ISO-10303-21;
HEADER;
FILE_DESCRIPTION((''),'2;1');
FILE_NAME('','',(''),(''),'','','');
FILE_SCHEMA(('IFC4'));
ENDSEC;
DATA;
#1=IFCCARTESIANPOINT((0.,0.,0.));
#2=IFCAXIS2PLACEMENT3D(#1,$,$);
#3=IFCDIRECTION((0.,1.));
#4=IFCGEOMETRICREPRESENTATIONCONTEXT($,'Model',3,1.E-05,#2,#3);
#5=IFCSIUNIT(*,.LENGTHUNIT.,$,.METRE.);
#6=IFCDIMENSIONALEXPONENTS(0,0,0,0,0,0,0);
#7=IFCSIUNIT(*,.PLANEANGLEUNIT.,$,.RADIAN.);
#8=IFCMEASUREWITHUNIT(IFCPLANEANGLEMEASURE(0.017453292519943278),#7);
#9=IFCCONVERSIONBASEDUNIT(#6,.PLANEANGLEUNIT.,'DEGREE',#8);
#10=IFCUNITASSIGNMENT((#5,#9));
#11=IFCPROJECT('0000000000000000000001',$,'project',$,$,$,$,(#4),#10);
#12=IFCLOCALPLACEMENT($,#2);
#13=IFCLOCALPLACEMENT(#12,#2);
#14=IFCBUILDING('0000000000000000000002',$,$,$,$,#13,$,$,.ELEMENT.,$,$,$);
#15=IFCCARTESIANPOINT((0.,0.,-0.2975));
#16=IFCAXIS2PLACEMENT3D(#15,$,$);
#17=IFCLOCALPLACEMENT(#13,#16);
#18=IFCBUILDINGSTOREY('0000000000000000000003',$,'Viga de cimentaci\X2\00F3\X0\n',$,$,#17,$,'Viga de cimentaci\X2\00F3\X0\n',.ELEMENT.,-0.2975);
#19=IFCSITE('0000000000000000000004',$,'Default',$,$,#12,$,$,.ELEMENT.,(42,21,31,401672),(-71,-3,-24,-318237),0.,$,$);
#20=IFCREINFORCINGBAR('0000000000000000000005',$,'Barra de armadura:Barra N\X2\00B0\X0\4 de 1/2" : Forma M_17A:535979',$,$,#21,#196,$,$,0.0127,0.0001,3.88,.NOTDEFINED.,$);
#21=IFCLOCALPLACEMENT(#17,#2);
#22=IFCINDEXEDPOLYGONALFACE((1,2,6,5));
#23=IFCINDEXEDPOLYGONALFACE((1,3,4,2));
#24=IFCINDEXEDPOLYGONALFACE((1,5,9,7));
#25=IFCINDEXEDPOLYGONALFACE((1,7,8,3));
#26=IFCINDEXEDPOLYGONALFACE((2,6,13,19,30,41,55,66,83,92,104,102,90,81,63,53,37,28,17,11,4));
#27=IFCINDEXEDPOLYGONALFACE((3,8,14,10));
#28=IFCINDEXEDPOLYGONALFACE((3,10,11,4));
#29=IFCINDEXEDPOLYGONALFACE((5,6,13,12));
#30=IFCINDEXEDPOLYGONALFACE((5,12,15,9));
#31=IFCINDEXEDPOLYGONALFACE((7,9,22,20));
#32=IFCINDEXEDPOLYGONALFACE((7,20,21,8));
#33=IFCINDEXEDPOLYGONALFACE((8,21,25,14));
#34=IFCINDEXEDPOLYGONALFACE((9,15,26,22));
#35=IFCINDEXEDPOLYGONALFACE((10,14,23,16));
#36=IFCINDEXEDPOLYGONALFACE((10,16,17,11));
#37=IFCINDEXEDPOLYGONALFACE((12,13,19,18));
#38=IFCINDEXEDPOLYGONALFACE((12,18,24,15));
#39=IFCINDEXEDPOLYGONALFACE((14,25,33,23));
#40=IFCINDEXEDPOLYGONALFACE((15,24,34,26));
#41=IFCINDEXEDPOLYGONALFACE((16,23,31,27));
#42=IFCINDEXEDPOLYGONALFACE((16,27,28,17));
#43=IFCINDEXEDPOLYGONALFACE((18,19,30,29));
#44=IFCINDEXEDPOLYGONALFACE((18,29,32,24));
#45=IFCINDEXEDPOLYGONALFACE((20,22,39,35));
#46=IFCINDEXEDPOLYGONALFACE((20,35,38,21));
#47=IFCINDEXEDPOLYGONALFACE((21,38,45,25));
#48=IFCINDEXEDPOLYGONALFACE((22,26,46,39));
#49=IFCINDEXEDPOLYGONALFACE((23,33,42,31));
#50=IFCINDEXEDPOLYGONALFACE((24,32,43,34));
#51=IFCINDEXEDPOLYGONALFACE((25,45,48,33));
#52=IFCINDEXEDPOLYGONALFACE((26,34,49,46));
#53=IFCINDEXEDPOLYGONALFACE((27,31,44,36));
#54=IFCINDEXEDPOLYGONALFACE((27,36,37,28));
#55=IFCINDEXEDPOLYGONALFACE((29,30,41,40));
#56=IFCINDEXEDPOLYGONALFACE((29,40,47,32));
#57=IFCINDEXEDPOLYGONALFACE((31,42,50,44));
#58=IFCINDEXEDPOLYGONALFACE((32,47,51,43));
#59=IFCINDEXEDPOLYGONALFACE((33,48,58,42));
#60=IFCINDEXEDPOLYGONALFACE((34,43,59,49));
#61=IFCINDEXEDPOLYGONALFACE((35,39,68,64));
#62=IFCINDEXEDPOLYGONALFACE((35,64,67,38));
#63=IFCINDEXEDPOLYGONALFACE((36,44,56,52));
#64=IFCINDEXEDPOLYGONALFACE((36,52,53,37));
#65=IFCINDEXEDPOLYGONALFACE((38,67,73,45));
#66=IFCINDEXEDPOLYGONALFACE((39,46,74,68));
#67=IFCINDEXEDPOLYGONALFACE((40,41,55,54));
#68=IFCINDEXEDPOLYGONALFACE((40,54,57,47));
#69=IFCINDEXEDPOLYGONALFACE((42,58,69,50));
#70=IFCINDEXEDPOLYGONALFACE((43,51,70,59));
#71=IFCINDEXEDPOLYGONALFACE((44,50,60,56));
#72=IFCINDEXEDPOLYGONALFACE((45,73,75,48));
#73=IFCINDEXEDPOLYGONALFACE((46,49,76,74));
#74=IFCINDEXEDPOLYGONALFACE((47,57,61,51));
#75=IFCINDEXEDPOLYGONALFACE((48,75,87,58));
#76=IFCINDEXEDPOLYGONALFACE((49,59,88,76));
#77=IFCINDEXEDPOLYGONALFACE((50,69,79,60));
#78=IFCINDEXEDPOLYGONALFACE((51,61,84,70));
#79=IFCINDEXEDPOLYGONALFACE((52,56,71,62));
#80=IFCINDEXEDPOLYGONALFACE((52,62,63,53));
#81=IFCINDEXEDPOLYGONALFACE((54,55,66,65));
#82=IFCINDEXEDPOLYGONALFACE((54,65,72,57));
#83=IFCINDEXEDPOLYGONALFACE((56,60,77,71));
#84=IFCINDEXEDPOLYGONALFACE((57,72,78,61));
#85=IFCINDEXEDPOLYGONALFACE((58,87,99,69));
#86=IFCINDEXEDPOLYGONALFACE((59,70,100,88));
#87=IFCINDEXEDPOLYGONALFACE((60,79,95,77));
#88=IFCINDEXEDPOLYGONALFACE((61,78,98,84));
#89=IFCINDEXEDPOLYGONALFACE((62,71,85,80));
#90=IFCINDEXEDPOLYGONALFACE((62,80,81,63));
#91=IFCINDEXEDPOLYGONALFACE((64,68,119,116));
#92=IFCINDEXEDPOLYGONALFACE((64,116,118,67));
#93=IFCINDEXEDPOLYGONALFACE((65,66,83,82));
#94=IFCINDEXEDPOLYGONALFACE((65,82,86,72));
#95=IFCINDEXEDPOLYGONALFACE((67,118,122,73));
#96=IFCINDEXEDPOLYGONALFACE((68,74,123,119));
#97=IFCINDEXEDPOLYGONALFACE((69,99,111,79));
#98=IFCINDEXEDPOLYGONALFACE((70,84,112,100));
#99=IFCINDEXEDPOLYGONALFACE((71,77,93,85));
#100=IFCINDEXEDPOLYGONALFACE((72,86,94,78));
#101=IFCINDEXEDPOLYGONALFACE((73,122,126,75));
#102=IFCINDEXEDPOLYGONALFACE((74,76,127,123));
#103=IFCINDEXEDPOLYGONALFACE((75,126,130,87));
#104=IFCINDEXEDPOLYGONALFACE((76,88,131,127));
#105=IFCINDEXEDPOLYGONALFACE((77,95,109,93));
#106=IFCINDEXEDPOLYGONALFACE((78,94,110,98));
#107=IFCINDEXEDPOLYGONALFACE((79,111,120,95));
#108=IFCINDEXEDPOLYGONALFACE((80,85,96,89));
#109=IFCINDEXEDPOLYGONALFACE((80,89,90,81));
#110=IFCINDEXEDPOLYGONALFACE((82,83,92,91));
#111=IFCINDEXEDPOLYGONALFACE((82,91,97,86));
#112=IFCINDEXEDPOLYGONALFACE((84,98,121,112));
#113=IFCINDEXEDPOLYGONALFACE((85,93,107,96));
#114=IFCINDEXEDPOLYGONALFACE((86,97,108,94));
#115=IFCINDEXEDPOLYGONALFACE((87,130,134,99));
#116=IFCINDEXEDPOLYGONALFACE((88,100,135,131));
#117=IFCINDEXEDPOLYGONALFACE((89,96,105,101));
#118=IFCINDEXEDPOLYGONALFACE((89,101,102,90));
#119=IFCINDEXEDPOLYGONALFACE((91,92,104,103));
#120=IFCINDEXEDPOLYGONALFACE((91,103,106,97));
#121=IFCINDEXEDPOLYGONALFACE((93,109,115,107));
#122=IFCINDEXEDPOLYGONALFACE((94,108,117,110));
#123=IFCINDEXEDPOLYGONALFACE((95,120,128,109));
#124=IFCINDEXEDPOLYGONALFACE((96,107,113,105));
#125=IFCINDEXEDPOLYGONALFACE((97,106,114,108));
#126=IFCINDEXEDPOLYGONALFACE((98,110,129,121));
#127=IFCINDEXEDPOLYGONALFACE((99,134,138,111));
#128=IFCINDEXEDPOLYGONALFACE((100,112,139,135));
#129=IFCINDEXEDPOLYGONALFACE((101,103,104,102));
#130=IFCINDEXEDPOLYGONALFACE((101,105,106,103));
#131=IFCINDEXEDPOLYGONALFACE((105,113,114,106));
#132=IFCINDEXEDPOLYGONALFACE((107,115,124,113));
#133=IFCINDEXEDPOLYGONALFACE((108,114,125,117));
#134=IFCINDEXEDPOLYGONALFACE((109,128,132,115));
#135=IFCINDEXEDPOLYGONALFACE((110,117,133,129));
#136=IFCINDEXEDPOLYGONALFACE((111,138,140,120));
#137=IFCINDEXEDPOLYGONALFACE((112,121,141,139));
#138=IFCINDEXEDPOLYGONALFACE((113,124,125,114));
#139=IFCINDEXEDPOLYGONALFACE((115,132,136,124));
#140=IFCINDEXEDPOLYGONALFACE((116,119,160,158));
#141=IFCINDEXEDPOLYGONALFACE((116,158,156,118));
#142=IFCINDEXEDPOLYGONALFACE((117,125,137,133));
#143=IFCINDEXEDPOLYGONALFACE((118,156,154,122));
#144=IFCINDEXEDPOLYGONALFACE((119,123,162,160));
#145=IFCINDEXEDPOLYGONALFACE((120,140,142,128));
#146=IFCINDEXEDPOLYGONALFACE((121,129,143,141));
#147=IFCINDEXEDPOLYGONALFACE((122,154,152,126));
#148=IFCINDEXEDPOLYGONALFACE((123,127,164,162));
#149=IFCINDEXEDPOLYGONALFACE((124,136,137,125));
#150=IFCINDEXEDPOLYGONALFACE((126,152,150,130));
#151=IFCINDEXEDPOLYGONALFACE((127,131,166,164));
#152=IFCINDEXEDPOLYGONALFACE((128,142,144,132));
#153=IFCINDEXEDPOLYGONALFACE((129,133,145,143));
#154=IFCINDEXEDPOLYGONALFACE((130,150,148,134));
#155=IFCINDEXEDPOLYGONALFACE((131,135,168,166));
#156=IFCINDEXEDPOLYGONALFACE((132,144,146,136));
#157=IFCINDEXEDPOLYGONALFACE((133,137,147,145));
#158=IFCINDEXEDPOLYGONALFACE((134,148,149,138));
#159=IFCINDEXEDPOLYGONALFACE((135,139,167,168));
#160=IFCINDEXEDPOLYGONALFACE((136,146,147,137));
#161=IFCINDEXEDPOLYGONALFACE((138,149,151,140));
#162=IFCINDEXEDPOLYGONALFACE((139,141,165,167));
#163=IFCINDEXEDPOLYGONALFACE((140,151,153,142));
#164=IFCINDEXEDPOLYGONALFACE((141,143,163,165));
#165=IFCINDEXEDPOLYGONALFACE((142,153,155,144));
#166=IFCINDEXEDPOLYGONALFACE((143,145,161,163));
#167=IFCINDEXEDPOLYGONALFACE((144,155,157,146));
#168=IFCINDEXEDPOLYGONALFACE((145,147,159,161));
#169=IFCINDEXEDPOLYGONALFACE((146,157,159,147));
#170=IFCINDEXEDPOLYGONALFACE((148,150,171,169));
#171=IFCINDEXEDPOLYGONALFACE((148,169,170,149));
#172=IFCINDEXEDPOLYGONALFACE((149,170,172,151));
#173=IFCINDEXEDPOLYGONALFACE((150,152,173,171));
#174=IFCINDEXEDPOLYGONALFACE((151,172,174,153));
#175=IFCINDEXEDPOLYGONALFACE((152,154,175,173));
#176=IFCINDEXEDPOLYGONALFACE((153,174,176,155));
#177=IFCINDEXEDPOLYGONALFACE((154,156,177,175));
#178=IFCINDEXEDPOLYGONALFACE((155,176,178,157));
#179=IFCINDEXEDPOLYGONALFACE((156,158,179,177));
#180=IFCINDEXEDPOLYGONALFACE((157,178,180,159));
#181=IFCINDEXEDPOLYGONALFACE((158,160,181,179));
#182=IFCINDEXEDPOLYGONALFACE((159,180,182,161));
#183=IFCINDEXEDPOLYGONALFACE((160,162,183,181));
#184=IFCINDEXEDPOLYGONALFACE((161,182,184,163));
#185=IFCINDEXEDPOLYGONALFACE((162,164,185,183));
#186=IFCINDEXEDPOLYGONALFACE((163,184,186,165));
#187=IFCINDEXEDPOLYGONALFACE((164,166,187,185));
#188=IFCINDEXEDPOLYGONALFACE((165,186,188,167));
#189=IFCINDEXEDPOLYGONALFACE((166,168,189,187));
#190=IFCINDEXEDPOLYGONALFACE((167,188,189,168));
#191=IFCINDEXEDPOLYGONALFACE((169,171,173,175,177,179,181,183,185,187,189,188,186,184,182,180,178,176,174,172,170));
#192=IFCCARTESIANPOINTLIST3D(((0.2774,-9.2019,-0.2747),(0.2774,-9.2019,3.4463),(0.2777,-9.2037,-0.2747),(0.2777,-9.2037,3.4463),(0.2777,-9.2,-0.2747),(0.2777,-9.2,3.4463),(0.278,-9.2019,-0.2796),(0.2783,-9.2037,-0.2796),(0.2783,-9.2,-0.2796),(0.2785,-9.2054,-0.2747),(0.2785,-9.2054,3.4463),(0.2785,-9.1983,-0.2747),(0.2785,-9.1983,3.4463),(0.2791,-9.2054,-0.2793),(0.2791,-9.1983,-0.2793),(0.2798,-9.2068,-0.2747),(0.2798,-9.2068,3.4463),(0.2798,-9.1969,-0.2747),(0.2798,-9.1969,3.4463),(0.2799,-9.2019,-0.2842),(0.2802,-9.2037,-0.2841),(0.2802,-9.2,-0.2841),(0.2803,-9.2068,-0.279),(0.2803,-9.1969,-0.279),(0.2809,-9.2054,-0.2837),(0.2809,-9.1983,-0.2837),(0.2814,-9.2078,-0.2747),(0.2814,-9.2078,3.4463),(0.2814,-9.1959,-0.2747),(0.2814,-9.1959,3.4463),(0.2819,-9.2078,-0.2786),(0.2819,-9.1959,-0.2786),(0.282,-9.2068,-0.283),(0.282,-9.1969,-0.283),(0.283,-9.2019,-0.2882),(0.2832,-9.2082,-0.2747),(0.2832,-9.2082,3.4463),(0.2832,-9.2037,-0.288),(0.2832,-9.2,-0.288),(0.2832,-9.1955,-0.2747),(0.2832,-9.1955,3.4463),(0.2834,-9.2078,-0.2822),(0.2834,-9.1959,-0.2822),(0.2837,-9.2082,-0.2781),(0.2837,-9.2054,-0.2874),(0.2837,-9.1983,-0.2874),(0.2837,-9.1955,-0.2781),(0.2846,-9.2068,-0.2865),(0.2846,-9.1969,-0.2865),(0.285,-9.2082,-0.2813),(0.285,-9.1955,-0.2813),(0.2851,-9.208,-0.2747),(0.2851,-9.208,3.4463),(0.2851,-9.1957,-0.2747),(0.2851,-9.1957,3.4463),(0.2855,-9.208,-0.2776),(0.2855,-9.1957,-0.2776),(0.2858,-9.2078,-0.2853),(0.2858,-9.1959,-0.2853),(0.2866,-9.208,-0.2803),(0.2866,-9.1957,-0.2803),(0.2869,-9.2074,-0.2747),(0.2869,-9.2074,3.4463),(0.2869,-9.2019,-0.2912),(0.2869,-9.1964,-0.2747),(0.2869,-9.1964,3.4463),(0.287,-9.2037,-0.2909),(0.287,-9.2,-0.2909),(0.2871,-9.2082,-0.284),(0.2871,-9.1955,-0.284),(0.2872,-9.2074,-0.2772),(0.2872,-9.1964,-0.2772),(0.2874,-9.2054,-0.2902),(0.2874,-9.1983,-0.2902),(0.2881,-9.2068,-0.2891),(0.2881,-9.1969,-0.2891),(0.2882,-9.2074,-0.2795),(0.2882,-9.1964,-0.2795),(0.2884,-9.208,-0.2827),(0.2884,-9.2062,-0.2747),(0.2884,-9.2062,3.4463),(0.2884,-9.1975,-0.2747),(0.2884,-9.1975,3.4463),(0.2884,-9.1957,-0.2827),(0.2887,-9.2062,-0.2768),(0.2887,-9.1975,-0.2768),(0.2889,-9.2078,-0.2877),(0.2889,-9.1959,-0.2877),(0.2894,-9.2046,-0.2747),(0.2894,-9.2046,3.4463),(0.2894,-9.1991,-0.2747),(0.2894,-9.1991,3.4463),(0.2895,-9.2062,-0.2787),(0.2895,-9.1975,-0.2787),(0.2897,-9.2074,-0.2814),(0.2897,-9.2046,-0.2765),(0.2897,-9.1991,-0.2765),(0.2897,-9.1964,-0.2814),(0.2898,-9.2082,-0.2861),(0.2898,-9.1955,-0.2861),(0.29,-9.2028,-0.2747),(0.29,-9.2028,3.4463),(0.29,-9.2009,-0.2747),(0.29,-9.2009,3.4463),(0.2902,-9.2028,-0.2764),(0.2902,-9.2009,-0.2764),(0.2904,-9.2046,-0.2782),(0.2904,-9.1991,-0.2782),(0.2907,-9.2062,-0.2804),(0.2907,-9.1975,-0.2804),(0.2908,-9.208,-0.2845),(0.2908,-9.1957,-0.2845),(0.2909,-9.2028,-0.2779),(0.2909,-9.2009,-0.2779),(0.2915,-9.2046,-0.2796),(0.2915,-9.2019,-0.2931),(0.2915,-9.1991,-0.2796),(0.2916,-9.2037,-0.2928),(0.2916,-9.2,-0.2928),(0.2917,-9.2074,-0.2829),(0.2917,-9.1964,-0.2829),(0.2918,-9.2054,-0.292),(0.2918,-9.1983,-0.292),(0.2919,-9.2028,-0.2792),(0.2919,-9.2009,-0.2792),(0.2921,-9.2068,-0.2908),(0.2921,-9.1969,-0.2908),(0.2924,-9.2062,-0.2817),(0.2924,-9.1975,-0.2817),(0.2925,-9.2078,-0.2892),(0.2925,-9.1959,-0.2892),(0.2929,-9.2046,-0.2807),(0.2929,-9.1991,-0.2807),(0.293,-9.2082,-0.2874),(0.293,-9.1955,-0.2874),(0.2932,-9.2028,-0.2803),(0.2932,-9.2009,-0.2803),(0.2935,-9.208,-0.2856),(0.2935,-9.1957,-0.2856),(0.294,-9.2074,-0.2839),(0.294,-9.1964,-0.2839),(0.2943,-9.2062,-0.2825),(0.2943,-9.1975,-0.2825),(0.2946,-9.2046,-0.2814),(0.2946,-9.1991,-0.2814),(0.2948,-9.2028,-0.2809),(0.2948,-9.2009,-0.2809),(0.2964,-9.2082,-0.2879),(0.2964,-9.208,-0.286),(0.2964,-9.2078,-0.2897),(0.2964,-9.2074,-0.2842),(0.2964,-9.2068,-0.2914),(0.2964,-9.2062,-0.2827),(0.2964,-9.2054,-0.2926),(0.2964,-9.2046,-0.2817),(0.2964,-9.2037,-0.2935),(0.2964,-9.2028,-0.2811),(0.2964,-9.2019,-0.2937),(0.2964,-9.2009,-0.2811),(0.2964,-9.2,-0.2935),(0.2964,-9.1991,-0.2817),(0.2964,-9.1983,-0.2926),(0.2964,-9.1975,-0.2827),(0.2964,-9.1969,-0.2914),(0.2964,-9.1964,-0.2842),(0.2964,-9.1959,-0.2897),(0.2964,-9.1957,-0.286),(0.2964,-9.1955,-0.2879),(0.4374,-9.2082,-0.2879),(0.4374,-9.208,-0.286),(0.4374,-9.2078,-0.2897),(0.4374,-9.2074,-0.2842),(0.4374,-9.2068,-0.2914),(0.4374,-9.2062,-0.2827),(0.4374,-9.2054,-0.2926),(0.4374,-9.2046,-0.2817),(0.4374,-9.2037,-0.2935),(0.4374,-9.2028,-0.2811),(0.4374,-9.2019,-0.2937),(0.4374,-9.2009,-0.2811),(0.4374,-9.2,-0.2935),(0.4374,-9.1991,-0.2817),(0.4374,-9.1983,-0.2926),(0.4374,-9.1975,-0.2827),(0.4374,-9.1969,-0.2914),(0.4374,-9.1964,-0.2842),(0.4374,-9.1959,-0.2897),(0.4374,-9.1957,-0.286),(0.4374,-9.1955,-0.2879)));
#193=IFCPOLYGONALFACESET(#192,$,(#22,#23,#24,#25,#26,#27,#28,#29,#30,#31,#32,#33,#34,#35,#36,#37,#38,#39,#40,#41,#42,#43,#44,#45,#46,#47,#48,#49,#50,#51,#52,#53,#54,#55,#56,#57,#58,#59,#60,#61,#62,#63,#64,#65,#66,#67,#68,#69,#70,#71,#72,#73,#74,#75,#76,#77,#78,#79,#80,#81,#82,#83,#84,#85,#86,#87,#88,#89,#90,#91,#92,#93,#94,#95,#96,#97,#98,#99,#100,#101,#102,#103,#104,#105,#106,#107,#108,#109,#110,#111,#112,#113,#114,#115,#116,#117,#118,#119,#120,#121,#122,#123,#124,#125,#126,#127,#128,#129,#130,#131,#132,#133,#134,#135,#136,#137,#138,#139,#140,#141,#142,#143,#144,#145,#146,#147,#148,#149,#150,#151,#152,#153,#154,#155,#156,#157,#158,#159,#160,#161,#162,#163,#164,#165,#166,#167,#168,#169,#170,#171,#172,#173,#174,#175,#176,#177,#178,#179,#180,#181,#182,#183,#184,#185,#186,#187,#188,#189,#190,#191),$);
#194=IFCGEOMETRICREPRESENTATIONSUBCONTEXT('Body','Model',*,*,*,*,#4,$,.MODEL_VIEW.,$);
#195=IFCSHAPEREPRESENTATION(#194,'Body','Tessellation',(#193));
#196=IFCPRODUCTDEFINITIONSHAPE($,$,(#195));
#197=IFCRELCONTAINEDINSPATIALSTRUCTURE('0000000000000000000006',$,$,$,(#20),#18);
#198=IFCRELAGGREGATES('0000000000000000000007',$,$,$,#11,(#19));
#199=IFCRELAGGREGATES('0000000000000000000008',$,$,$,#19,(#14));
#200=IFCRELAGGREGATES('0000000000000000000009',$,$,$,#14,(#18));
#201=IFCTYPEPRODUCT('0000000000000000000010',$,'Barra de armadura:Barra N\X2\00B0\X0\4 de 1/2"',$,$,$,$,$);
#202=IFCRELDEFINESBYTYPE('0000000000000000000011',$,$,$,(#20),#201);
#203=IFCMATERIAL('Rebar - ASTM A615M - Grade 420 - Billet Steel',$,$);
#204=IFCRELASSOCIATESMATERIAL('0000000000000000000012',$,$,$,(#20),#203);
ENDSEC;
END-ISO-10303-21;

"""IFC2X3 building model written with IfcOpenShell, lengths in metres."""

from ifc_helpers import new_model, entity, si_unit, converted_unit, direction, frame, origin, place, context, subcontext, project, spatial, material, type_object, element, save


model = new_model("IFC2X3")

# Units and contexts
model_context = context("Model", 3, precision=1e-05, world=origin(), true_north=direction((0.0, 1.0)))
body_context = subcontext(model_context, "Body", "Model", "MODEL_VIEW")
ifc_project = project(units=[si_unit("LENGTHUNIT", "METRE"), converted_unit("PLANEANGLEUNIT", "DEGREE", entity("IfcPlaneAngleMeasure", 0.017453292519943278), si_unit("PLANEANGLEUNIT", "RADIAN"), dimensions=[0, 0, 0, 0, 0, 0, 0])], contexts=[model_context])

# Site, building, storey
site_placement = place(None, origin())
site = spatial("IfcSite", under=ifc_project, at=site_placement, Name="Default", CompositionType="ELEMENT", RefLatitude=(42, 21, 31, 401672), RefLongitude=(-71, -3, -24, -318237), RefElevation=0.0)
building_placement = place(site_placement, origin())
building = spatial("IfcBuilding", under=site, at=building_placement, CompositionType="ELEMENT")
storey_placement = place(building_placement, frame((0.0, 0.0, -0.2975)))
storey = spatial("IfcBuildingStorey", under=building, at=storey_placement, Name="Viga de cimentación", LongName="Viga de cimentación", CompositionType="ELEMENT", Elevation=-0.2975)

# Reinforcing bar
ifc_material = material(Name="Rebar - ASTM A615M - Grade 420 - Billet Steel")
type_product_1 = type_object("IfcTypeProduct", Name="Barra de armadura:Barra N°4 de 1/2\"")
reinforcing_bar_1_placement = place(storey_placement, origin())
element("IfcReinforcingBar", 1, at=reinforcing_bar_1_placement, inside=storey, type_object=type_product_1, material=ifc_material, Name="Barra de armadura:Barra N°4 de 1/2\" : Forma M_17A:535979", BarLength=3.88, BarRole="NOTDEFINED", CrossSectionArea=0.0001, NominalDiameter=0.0127, context=body_context, shape_type="AdvancedSweptSolid", body=[
    entity("IfcSweptDiskSolid", entity("IfcCompositeCurve", [entity("IfcCompositeCurveSegment", "CONTINUOUS", True, entity("IfcPolyline", [entity("IfcCartesianPoint", [0.2837, -9.2019, 3.4463]), entity("IfcCartesianPoint", [0.2837, -9.2019, -0.2747])])), entity("IfcCompositeCurveSegment", "CONTINUOUS", True, entity("IfcTrimmedCurve", entity("IfcCircle", entity("IfcAxis2Placement3D", entity("IfcCartesianPoint", [0.2964, -9.2019, -0.2747]), entity("IfcDirection", [0.0, -1.0, 0.0]), entity("IfcDirection", [0.0, 0.0, -1.0])), 0.0127), [entity("IfcParameterValue", 270.0)], [entity("IfcParameterValue", 360.0)], True, "PARAMETER")), entity("IfcCompositeCurveSegment", "CONTINUOUS", True, entity("IfcPolyline", [entity("IfcCartesianPoint", [0.2964, -9.2019, -0.2874]), entity("IfcCartesianPoint", [0.4374, -9.2019, -0.2874])]))], False), 0.0063, None, 0.0, 92.0),
])

save(model, "model.ifc")
